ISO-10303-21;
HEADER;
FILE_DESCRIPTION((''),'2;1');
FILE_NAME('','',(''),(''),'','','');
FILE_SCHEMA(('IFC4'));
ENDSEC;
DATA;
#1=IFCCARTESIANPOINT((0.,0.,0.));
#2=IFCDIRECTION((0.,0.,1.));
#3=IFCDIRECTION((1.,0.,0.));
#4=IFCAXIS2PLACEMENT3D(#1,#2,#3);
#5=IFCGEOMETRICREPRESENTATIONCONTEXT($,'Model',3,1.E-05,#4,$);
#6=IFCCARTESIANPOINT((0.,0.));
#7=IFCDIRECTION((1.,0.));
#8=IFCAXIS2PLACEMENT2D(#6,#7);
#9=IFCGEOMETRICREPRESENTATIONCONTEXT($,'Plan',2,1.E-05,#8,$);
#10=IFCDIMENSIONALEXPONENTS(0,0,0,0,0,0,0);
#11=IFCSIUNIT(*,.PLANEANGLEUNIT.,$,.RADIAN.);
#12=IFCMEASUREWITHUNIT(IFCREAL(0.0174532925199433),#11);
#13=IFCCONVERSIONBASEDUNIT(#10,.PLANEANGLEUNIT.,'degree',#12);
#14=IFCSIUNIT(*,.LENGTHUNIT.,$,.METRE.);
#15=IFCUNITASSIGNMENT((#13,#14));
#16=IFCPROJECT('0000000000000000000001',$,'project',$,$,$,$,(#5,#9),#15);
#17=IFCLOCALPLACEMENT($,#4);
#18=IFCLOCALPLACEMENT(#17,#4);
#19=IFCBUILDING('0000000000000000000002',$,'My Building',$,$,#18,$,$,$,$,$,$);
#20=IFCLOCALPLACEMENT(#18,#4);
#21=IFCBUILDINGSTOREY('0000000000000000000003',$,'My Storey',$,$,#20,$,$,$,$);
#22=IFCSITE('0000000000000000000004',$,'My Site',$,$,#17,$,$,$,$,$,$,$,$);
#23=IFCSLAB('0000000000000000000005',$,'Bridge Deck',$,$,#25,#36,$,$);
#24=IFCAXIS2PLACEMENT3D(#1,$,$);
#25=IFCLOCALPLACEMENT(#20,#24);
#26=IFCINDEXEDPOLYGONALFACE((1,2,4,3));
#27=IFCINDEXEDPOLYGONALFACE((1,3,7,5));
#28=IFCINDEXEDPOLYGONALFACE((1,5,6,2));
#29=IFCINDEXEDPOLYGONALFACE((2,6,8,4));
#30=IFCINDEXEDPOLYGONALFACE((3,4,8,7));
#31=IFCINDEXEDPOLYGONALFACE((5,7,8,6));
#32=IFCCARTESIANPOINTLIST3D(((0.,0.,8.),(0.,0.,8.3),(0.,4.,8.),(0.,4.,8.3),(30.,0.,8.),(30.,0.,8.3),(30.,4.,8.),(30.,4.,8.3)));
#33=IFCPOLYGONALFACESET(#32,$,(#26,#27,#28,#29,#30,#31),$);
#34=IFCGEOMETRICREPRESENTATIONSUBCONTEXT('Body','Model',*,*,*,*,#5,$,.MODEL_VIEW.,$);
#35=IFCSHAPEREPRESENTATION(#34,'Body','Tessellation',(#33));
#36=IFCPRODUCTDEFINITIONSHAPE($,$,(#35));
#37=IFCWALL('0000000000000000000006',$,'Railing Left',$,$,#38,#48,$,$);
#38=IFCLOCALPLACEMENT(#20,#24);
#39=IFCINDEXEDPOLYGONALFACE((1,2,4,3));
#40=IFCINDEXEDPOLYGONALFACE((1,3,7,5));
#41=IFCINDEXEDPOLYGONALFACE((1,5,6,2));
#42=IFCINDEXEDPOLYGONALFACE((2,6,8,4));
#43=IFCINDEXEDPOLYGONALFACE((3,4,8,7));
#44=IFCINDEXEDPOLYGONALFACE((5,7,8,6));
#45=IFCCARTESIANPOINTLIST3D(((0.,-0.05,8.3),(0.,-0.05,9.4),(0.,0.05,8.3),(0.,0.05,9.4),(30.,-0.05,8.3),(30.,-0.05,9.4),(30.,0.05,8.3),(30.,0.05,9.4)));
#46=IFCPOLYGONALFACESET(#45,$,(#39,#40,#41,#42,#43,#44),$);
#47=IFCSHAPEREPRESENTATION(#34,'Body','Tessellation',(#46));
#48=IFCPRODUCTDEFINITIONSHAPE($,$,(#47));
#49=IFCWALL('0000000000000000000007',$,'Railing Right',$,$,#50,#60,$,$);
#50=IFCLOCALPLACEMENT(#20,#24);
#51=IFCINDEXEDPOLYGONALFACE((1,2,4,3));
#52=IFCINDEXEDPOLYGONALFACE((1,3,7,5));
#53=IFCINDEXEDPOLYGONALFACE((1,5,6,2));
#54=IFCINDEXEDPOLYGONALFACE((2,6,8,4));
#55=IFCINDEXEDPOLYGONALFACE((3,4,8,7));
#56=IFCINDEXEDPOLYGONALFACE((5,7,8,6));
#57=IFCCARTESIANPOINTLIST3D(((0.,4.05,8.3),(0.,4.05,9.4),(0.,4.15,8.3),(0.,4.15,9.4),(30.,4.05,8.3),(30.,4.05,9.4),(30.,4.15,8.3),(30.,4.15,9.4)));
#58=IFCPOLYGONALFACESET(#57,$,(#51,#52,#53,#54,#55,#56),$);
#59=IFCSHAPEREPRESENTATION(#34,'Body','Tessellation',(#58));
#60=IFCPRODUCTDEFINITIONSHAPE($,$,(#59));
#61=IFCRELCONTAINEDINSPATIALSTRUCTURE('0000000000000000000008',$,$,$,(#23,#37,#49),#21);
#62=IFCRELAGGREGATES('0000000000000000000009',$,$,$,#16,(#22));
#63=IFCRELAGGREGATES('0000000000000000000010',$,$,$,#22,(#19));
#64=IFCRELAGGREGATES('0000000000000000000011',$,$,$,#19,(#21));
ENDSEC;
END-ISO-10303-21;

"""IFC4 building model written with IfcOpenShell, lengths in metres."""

from ifc_helpers import new_model, entity, si_unit, converted_unit, frame, origin_with_axes, origin_2d_with_axis, place, context, subcontext, project, spatial, indexed_curve, outline, extrude, element, save


model = new_model("IFC4")

# Units and contexts
model_context = context("Model", 3, precision=1e-05, world=origin_with_axes())
plan_context = context("Plan", 2, precision=1e-05, world=origin_2d_with_axis())
body_context = subcontext(model_context, "Body", "Model", "MODEL_VIEW")
ifc_project = project(units=[converted_unit("PLANEANGLEUNIT", "degree", entity("IfcReal", 0.0174532925199433), si_unit("PLANEANGLEUNIT", "RADIAN"), dimensions=[0, 0, 0, 0, 0, 0, 0]), si_unit("LENGTHUNIT", "METRE")], contexts=[model_context, plan_context])

# Site, building, storey
site_placement = place(None, origin_with_axes())
site = spatial("IfcSite", under=ifc_project, at=site_placement, Name="My Site")
building_placement = place(site_placement, origin_with_axes())
building = spatial("IfcBuilding", under=site, at=building_placement, Name="My Building")
storey_placement = place(building_placement, origin_with_axes())
storey = spatial("IfcBuildingStorey", under=building, at=storey_placement, Name="My Storey")

# Slab
slab_placement = place(storey_placement, frame((0.0, 0.0, 8.0), z_axis=(0.0, 0.0, 1.0), x_axis=(1.0, 0.0, 0.0)))
element("IfcSlab", 1, at=slab_placement, inside=storey, Name="Bridge Deck", context=body_context, shape_type="SweptSolid", body=[
    extrude(outline(indexed_curve([(0.0, 0.0), (30.0, 0.0), (30.0, 4.0), (0.0, 4.0)])), None, (0.0, 0.0, 1.0), 0.3),
])

# Walls
for number, where, z_axis, x_axis, name in (
    (2, (0.0, -0.05, 8.3), (0.0, 0.0, 1.0), (1.0, 0.0, 0.0), "Railing Left"),
    (3, (0.0, 4.05, 8.3), (0.0, 0.0, 1.0), (1.0, 0.0, 0.0), "Railing Right"),
):
    element("IfcWall", number, at=place(storey_placement, frame(where, z_axis=z_axis, x_axis=x_axis)), inside=storey, Name=name, context=body_context, shape_type="SweptSolid", body=[
        extrude(outline(indexed_curve([(0.0, 0.0), (0.0, 0.1), (30.0, 0.1), (30.0, 0.0), (0.0, 0.0)], self_intersect=False)), origin_with_axes(), (0.0, 0.0, 1.0), 1.1),
    ])

save(model, "model.ifc")
